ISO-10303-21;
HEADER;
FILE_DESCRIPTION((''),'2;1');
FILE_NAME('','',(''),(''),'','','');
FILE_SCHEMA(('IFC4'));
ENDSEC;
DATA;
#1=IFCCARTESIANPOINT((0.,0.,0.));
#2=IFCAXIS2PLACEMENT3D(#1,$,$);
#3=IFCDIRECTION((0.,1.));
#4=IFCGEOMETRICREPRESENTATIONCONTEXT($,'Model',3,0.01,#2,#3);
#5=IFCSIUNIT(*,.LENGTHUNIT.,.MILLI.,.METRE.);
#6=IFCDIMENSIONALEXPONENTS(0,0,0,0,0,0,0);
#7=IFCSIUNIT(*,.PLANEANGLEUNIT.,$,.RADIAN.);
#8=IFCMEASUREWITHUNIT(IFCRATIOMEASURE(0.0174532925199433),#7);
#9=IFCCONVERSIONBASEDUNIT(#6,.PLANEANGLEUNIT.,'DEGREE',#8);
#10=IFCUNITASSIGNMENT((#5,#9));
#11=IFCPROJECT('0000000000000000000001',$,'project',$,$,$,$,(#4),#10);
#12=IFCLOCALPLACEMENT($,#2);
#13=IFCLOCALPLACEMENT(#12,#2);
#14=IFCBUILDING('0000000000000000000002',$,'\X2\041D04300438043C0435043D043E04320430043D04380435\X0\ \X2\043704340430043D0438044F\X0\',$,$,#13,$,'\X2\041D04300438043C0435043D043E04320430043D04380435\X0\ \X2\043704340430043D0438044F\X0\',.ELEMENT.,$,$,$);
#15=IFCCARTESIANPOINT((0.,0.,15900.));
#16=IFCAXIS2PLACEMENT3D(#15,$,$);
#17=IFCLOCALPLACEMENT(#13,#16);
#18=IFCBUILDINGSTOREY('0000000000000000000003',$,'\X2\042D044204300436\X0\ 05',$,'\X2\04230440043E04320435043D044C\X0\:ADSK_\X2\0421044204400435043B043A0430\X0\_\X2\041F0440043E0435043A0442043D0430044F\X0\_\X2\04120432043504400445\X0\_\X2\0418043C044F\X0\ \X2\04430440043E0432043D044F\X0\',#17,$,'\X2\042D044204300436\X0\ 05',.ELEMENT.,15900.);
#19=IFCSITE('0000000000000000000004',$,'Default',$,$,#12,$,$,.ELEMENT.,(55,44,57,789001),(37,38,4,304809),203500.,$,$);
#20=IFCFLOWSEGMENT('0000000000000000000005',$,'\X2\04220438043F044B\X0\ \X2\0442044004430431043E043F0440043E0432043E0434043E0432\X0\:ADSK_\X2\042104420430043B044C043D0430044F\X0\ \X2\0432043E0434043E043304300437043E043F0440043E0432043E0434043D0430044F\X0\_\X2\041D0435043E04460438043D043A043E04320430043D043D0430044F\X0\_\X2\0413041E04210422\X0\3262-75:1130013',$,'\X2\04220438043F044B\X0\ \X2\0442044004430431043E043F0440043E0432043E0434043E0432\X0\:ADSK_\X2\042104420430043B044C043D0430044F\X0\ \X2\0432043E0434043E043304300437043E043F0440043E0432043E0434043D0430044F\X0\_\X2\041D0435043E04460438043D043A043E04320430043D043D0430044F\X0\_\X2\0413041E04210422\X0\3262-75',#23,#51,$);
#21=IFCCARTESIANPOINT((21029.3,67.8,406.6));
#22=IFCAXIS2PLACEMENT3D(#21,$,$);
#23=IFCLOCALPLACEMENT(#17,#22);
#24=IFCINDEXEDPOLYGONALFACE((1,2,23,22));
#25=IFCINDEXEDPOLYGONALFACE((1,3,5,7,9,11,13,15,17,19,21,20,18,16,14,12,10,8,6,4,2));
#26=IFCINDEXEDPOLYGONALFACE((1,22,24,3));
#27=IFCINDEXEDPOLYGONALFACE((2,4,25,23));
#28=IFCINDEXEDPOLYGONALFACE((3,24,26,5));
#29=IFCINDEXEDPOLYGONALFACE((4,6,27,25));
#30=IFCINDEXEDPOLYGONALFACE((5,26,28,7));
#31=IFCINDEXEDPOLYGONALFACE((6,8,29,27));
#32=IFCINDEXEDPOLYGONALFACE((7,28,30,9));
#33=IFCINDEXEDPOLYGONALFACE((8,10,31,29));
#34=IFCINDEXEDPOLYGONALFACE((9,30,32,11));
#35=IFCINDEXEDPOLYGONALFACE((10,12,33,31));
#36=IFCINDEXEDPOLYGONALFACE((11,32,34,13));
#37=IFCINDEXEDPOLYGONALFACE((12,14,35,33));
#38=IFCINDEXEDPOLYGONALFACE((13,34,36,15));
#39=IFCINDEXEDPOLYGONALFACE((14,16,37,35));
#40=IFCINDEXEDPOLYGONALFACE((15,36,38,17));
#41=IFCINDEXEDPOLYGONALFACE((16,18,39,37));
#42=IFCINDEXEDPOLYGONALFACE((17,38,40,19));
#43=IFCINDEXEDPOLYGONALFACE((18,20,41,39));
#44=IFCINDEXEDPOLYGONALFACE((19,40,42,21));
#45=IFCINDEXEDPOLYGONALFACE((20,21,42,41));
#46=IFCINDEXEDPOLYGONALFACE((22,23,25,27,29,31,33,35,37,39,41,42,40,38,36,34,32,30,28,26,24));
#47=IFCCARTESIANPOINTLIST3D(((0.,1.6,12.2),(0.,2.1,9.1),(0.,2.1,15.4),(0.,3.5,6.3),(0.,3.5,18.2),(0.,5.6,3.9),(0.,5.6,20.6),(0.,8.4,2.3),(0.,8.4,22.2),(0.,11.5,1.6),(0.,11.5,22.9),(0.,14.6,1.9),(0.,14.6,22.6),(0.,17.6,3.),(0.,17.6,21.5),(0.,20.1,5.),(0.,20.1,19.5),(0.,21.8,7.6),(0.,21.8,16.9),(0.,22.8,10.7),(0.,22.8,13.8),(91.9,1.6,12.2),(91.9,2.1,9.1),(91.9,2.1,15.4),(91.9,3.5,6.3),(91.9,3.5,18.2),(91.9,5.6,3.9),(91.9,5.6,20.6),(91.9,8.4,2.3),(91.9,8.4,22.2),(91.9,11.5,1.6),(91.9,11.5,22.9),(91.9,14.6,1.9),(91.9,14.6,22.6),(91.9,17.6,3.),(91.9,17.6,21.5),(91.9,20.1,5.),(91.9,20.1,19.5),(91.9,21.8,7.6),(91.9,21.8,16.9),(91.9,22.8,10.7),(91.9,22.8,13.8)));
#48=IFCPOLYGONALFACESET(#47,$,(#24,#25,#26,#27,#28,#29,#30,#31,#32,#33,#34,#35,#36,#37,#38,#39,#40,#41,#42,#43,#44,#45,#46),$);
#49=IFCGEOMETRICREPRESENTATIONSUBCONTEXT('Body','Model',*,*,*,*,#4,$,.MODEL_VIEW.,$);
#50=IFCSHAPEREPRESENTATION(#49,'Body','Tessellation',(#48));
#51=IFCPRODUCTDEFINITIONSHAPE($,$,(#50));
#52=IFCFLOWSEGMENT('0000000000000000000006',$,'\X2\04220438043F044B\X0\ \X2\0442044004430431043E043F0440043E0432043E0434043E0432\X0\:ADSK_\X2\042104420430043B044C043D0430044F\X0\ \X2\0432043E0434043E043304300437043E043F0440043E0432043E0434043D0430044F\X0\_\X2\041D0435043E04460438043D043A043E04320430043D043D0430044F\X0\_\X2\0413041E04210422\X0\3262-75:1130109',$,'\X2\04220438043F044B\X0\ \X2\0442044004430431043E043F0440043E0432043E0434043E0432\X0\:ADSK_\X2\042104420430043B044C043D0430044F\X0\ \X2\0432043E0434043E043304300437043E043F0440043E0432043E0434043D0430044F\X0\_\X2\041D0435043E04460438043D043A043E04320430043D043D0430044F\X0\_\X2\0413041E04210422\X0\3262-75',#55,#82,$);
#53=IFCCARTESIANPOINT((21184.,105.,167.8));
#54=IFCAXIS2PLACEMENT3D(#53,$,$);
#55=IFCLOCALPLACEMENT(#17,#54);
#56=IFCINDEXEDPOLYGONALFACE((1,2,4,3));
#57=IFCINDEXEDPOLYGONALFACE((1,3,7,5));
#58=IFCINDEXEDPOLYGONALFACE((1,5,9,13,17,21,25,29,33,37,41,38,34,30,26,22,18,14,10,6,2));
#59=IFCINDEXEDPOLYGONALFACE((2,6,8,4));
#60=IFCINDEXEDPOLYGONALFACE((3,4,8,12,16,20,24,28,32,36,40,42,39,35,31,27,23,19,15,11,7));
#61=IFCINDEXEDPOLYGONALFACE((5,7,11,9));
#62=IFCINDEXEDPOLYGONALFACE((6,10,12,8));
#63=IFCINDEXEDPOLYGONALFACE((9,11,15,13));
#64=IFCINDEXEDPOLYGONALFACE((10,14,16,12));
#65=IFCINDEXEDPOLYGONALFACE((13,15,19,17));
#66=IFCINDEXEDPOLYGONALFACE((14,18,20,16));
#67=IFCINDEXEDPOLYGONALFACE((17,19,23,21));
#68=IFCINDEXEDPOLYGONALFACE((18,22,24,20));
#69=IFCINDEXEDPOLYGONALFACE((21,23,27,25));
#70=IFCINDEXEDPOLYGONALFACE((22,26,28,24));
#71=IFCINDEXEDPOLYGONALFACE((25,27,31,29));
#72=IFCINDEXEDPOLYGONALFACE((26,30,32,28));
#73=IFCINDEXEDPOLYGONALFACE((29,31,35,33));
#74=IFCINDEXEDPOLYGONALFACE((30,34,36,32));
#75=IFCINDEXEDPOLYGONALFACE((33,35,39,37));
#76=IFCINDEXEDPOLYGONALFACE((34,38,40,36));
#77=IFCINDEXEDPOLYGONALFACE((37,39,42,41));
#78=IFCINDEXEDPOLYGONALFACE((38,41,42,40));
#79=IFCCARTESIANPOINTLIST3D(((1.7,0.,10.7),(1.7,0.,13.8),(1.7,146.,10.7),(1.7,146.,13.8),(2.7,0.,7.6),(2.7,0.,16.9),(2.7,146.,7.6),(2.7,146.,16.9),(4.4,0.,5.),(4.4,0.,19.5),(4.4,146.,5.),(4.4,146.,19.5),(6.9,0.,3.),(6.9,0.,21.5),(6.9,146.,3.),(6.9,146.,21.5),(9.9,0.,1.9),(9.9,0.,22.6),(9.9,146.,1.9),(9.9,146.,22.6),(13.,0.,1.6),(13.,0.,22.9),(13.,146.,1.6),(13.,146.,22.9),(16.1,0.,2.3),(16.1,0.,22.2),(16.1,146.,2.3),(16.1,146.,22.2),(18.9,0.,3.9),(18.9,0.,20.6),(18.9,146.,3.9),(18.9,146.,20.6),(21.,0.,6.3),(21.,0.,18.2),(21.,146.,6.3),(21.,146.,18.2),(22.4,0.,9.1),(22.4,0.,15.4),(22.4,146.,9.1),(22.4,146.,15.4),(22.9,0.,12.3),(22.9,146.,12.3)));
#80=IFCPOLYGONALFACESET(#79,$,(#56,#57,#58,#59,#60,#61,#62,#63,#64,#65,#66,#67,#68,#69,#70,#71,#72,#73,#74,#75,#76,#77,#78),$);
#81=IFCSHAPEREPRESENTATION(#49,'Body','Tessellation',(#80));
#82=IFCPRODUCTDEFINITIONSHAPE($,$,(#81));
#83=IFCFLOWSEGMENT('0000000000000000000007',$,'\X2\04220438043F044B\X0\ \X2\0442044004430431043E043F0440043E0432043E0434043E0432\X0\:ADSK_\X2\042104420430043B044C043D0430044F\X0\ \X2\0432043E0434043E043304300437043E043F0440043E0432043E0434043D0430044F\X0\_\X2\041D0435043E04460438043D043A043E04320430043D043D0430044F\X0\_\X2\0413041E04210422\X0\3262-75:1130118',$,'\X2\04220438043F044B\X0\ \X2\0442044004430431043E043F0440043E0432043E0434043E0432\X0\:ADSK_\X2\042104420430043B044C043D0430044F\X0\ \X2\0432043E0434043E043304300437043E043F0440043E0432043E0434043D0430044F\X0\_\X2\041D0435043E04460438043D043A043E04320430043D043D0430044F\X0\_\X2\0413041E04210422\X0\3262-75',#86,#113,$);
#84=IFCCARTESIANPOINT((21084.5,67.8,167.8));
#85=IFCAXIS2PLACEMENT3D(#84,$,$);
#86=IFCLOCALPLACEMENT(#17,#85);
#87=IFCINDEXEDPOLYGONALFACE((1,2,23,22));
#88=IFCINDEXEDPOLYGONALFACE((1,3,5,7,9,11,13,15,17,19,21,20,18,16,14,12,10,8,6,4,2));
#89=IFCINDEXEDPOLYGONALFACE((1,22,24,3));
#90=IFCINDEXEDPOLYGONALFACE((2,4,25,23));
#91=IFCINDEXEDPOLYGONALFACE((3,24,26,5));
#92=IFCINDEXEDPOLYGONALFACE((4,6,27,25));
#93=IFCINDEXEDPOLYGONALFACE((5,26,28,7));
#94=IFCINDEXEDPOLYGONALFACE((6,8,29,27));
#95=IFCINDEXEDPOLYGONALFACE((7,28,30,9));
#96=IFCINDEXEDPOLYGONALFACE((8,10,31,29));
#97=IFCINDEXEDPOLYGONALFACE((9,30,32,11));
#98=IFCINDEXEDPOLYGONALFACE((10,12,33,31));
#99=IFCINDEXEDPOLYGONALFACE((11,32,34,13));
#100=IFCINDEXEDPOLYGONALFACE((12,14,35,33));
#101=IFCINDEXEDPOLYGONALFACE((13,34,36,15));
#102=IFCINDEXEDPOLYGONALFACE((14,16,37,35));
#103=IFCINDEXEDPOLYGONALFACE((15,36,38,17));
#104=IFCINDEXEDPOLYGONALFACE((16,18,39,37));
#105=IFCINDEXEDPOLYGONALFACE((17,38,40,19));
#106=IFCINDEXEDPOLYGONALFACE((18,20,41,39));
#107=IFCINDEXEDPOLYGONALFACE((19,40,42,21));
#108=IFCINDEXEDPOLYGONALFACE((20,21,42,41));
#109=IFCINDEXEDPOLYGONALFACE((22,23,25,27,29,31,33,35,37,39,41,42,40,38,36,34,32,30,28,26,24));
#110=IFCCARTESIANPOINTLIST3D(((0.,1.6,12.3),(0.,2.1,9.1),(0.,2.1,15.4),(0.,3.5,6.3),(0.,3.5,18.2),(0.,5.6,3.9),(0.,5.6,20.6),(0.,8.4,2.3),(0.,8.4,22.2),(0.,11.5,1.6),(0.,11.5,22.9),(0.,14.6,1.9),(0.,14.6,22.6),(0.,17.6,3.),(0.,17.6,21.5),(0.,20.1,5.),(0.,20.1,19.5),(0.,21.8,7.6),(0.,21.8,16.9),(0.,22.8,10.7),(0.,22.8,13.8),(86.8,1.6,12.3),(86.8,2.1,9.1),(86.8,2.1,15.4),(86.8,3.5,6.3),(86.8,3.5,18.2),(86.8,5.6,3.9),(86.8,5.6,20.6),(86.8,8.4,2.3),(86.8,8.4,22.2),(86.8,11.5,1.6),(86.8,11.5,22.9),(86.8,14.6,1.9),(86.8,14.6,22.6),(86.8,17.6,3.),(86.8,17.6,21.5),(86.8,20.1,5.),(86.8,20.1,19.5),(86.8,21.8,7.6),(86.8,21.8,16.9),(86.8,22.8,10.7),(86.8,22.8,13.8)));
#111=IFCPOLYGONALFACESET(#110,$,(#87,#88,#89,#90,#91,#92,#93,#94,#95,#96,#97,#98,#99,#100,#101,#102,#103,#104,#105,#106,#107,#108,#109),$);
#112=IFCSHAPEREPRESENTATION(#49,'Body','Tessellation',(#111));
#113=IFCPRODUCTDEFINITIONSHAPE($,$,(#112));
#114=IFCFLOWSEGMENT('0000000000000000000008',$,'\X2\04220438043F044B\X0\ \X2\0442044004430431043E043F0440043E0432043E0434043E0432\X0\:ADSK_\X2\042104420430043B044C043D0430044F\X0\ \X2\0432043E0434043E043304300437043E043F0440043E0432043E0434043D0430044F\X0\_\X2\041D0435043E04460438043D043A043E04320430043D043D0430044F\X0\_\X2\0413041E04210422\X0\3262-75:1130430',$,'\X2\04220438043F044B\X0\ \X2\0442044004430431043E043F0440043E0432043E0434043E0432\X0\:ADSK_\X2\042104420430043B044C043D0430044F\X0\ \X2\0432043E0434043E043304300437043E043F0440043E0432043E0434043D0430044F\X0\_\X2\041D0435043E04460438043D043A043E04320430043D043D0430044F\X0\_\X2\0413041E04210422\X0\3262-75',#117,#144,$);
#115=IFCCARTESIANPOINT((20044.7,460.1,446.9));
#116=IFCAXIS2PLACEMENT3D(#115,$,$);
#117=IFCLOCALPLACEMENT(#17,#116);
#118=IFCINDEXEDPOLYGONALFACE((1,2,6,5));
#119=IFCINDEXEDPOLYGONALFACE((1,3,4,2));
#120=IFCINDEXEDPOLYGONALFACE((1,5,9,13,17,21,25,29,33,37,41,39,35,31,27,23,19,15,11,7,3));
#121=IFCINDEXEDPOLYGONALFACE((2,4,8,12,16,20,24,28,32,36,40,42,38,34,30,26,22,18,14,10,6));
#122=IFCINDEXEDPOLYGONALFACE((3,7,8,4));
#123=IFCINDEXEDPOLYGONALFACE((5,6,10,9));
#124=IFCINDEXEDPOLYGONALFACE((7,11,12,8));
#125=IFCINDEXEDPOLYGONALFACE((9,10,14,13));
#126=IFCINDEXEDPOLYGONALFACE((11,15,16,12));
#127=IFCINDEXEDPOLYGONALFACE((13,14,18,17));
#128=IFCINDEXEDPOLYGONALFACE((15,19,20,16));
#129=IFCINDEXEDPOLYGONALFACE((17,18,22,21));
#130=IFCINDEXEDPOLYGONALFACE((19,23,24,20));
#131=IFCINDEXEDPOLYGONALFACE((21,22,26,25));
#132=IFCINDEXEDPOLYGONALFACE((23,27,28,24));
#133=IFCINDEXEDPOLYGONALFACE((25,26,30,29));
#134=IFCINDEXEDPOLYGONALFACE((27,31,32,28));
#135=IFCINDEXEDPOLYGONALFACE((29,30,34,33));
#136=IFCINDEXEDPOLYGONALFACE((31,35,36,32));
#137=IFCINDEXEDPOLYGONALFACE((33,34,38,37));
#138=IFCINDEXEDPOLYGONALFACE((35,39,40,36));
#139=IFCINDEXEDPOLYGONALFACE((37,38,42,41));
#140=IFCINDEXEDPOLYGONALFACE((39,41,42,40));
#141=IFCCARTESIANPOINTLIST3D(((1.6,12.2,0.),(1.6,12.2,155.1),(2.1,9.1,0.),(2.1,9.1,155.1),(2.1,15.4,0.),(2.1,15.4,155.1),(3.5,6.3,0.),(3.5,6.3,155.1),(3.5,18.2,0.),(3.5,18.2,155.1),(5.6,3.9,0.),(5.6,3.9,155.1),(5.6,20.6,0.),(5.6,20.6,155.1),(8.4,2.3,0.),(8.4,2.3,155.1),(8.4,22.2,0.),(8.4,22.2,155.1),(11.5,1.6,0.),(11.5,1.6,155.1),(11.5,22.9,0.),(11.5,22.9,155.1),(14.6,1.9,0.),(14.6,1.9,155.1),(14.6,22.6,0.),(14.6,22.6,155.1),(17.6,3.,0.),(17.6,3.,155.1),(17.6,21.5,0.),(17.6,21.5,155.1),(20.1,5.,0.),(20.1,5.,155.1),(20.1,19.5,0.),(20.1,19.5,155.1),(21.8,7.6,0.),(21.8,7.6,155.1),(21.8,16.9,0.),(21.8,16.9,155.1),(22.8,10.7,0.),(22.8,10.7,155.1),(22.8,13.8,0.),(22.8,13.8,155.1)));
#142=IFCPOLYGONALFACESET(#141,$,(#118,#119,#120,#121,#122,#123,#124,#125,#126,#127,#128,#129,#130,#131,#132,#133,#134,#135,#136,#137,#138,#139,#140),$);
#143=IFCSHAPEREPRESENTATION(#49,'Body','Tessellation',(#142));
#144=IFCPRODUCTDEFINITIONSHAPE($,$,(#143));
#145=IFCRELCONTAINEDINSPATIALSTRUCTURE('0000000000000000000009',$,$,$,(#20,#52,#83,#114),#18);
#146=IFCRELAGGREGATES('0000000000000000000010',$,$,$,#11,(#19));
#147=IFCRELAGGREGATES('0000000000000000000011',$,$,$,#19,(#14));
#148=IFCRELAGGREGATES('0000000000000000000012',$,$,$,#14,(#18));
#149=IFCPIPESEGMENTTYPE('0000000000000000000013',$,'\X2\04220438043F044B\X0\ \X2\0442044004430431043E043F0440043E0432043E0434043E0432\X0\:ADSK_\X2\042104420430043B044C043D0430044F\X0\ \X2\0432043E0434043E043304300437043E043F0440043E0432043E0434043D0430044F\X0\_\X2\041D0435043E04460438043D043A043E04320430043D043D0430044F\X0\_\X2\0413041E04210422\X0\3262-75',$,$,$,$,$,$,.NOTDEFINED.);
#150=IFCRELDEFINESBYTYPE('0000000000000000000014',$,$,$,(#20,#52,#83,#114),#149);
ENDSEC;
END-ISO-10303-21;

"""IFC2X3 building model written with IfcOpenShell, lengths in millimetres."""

from ifc_helpers import new_model, entity, si_unit, converted_unit, direction, frame, origin, origin_2d_with_axis, place, context, subcontext, project, spatial, circle, extrude, type_object, element, save


model = new_model("IFC2X3")

# Units and contexts
model_context = context("Model", 3, precision=0.01, world=origin(), true_north=direction((0.0, 1.0)))
body_context = subcontext(model_context, "Body", "Model", "MODEL_VIEW")
ifc_project = project(units=[si_unit("LENGTHUNIT", "METRE", prefix="MILLI"), converted_unit("PLANEANGLEUNIT", "DEGREE", entity("IfcRatioMeasure", 0.0174532925199433), si_unit("PLANEANGLEUNIT", "RADIAN"), dimensions=[0, 0, 0, 0, 0, 0, 0])], contexts=[model_context])

# Site, building, storey
site_placement = place(None, origin())
site = spatial("IfcSite", under=ifc_project, at=site_placement, Name="Default", CompositionType="ELEMENT", RefLatitude=(55, 44, 57, 789001), RefLongitude=(37, 38, 4, 304809), RefElevation=203500.0)
building_placement = place(site_placement, origin())
building = spatial("IfcBuilding", under=site, at=building_placement, Name="Наименование здания", LongName="Наименование здания", CompositionType="ELEMENT")
storey_placement = place(building_placement, frame((0.0, 0.0, 15900.0)))
storey = spatial("IfcBuildingStorey", under=building, at=storey_placement, Name="Этаж 05", ObjectType="Уровень:ADSK_Стрелка_Проектная_Вверх_Имя уровня", LongName="Этаж 05", CompositionType="ELEMENT", Elevation=15900.0)

# Flow segments
pipe_segment_type = type_object("IfcPipeSegmentType", Name="Типы трубопроводов:ADSK_Стальная водогазопроводная_Неоцинкованная_ГОСТ3262-75", PredefinedType="NOTDEFINED")
flow_segment_1_placement = place(storey_placement, frame((21029.3, 67.8, 406.6)))
element("IfcFlowSegment", 1, at=flow_segment_1_placement, inside=storey, type_object=pipe_segment_type, Name="Типы трубопроводов:ADSK_Стальная водогазопроводная_Неоцинкованная_ГОСТ3262-75:1130013", ObjectType="Типы трубопроводов:ADSK_Стальная водогазопроводная_Неоцинкованная_ГОСТ3262-75", context=body_context, shape_type="SweptSolid", body=[
    extrude(circle(Radius=10.7, at=origin_2d_with_axis()), frame((0.0, 12.2, 12.2), z_axis=(1.0, 0.0, 0.0), x_axis=(0.0, -1.0, 0.0)), (0.0, 0.0, 1.0), 91.9),
])
flow_segment_2_placement = place(storey_placement, frame((21184.0, 105.0, 167.8)))
element("IfcFlowSegment", 2, at=flow_segment_2_placement, inside=storey, type_object=pipe_segment_type, Name="Типы трубопроводов:ADSK_Стальная водогазопроводная_Неоцинкованная_ГОСТ3262-75:1130109", ObjectType="Типы трубопроводов:ADSK_Стальная водогазопроводная_Неоцинкованная_ГОСТ3262-75", context=body_context, shape_type="SweptSolid", body=[
    extrude(circle(Radius=10.7, at=origin_2d_with_axis()), frame((12.2, 0.0, 12.2), z_axis=(0.0, 1.0, 0.0), x_axis=(1.0, 0.0, 0.0)), (0.0, 0.0, 1.0), 146.0),
])
flow_segment_3_placement = place(storey_placement, frame((21084.5, 67.8, 167.8)))
element("IfcFlowSegment", 3, at=flow_segment_3_placement, inside=storey, type_object=pipe_segment_type, Name="Типы трубопроводов:ADSK_Стальная водогазопроводная_Неоцинкованная_ГОСТ3262-75:1130118", ObjectType="Типы трубопроводов:ADSK_Стальная водогазопроводная_Неоцинкованная_ГОСТ3262-75", context=body_context, shape_type="SweptSolid", body=[
    extrude(circle(Radius=10.7, at=origin_2d_with_axis()), frame((0.0, 12.2, 12.2), z_axis=(1.0, 0.0, 0.0), x_axis=(0.0, -1.0, 0.0)), (0.0, 0.0, 1.0), 86.8),
])
flow_segment_4_placement = place(storey_placement, frame((20044.7, 460.1, 446.9)))
element("IfcFlowSegment", 4, at=flow_segment_4_placement, inside=storey, type_object=pipe_segment_type, Name="Типы трубопроводов:ADSK_Стальная водогазопроводная_Неоцинкованная_ГОСТ3262-75:1130430", ObjectType="Типы трубопроводов:ADSK_Стальная водогазопроводная_Неоцинкованная_ГОСТ3262-75", context=body_context, shape_type="SweptSolid", body=[
    extrude(circle(Radius=10.7, at=origin_2d_with_axis()), frame((12.2, 12.2, 0.0), z_axis=(0.0, 0.0, 1.0), x_axis=(-1.0, 0.0, 0.0)), (0.0, 0.0, 1.0), 155.1),
])

save(model, "model.ifc")
